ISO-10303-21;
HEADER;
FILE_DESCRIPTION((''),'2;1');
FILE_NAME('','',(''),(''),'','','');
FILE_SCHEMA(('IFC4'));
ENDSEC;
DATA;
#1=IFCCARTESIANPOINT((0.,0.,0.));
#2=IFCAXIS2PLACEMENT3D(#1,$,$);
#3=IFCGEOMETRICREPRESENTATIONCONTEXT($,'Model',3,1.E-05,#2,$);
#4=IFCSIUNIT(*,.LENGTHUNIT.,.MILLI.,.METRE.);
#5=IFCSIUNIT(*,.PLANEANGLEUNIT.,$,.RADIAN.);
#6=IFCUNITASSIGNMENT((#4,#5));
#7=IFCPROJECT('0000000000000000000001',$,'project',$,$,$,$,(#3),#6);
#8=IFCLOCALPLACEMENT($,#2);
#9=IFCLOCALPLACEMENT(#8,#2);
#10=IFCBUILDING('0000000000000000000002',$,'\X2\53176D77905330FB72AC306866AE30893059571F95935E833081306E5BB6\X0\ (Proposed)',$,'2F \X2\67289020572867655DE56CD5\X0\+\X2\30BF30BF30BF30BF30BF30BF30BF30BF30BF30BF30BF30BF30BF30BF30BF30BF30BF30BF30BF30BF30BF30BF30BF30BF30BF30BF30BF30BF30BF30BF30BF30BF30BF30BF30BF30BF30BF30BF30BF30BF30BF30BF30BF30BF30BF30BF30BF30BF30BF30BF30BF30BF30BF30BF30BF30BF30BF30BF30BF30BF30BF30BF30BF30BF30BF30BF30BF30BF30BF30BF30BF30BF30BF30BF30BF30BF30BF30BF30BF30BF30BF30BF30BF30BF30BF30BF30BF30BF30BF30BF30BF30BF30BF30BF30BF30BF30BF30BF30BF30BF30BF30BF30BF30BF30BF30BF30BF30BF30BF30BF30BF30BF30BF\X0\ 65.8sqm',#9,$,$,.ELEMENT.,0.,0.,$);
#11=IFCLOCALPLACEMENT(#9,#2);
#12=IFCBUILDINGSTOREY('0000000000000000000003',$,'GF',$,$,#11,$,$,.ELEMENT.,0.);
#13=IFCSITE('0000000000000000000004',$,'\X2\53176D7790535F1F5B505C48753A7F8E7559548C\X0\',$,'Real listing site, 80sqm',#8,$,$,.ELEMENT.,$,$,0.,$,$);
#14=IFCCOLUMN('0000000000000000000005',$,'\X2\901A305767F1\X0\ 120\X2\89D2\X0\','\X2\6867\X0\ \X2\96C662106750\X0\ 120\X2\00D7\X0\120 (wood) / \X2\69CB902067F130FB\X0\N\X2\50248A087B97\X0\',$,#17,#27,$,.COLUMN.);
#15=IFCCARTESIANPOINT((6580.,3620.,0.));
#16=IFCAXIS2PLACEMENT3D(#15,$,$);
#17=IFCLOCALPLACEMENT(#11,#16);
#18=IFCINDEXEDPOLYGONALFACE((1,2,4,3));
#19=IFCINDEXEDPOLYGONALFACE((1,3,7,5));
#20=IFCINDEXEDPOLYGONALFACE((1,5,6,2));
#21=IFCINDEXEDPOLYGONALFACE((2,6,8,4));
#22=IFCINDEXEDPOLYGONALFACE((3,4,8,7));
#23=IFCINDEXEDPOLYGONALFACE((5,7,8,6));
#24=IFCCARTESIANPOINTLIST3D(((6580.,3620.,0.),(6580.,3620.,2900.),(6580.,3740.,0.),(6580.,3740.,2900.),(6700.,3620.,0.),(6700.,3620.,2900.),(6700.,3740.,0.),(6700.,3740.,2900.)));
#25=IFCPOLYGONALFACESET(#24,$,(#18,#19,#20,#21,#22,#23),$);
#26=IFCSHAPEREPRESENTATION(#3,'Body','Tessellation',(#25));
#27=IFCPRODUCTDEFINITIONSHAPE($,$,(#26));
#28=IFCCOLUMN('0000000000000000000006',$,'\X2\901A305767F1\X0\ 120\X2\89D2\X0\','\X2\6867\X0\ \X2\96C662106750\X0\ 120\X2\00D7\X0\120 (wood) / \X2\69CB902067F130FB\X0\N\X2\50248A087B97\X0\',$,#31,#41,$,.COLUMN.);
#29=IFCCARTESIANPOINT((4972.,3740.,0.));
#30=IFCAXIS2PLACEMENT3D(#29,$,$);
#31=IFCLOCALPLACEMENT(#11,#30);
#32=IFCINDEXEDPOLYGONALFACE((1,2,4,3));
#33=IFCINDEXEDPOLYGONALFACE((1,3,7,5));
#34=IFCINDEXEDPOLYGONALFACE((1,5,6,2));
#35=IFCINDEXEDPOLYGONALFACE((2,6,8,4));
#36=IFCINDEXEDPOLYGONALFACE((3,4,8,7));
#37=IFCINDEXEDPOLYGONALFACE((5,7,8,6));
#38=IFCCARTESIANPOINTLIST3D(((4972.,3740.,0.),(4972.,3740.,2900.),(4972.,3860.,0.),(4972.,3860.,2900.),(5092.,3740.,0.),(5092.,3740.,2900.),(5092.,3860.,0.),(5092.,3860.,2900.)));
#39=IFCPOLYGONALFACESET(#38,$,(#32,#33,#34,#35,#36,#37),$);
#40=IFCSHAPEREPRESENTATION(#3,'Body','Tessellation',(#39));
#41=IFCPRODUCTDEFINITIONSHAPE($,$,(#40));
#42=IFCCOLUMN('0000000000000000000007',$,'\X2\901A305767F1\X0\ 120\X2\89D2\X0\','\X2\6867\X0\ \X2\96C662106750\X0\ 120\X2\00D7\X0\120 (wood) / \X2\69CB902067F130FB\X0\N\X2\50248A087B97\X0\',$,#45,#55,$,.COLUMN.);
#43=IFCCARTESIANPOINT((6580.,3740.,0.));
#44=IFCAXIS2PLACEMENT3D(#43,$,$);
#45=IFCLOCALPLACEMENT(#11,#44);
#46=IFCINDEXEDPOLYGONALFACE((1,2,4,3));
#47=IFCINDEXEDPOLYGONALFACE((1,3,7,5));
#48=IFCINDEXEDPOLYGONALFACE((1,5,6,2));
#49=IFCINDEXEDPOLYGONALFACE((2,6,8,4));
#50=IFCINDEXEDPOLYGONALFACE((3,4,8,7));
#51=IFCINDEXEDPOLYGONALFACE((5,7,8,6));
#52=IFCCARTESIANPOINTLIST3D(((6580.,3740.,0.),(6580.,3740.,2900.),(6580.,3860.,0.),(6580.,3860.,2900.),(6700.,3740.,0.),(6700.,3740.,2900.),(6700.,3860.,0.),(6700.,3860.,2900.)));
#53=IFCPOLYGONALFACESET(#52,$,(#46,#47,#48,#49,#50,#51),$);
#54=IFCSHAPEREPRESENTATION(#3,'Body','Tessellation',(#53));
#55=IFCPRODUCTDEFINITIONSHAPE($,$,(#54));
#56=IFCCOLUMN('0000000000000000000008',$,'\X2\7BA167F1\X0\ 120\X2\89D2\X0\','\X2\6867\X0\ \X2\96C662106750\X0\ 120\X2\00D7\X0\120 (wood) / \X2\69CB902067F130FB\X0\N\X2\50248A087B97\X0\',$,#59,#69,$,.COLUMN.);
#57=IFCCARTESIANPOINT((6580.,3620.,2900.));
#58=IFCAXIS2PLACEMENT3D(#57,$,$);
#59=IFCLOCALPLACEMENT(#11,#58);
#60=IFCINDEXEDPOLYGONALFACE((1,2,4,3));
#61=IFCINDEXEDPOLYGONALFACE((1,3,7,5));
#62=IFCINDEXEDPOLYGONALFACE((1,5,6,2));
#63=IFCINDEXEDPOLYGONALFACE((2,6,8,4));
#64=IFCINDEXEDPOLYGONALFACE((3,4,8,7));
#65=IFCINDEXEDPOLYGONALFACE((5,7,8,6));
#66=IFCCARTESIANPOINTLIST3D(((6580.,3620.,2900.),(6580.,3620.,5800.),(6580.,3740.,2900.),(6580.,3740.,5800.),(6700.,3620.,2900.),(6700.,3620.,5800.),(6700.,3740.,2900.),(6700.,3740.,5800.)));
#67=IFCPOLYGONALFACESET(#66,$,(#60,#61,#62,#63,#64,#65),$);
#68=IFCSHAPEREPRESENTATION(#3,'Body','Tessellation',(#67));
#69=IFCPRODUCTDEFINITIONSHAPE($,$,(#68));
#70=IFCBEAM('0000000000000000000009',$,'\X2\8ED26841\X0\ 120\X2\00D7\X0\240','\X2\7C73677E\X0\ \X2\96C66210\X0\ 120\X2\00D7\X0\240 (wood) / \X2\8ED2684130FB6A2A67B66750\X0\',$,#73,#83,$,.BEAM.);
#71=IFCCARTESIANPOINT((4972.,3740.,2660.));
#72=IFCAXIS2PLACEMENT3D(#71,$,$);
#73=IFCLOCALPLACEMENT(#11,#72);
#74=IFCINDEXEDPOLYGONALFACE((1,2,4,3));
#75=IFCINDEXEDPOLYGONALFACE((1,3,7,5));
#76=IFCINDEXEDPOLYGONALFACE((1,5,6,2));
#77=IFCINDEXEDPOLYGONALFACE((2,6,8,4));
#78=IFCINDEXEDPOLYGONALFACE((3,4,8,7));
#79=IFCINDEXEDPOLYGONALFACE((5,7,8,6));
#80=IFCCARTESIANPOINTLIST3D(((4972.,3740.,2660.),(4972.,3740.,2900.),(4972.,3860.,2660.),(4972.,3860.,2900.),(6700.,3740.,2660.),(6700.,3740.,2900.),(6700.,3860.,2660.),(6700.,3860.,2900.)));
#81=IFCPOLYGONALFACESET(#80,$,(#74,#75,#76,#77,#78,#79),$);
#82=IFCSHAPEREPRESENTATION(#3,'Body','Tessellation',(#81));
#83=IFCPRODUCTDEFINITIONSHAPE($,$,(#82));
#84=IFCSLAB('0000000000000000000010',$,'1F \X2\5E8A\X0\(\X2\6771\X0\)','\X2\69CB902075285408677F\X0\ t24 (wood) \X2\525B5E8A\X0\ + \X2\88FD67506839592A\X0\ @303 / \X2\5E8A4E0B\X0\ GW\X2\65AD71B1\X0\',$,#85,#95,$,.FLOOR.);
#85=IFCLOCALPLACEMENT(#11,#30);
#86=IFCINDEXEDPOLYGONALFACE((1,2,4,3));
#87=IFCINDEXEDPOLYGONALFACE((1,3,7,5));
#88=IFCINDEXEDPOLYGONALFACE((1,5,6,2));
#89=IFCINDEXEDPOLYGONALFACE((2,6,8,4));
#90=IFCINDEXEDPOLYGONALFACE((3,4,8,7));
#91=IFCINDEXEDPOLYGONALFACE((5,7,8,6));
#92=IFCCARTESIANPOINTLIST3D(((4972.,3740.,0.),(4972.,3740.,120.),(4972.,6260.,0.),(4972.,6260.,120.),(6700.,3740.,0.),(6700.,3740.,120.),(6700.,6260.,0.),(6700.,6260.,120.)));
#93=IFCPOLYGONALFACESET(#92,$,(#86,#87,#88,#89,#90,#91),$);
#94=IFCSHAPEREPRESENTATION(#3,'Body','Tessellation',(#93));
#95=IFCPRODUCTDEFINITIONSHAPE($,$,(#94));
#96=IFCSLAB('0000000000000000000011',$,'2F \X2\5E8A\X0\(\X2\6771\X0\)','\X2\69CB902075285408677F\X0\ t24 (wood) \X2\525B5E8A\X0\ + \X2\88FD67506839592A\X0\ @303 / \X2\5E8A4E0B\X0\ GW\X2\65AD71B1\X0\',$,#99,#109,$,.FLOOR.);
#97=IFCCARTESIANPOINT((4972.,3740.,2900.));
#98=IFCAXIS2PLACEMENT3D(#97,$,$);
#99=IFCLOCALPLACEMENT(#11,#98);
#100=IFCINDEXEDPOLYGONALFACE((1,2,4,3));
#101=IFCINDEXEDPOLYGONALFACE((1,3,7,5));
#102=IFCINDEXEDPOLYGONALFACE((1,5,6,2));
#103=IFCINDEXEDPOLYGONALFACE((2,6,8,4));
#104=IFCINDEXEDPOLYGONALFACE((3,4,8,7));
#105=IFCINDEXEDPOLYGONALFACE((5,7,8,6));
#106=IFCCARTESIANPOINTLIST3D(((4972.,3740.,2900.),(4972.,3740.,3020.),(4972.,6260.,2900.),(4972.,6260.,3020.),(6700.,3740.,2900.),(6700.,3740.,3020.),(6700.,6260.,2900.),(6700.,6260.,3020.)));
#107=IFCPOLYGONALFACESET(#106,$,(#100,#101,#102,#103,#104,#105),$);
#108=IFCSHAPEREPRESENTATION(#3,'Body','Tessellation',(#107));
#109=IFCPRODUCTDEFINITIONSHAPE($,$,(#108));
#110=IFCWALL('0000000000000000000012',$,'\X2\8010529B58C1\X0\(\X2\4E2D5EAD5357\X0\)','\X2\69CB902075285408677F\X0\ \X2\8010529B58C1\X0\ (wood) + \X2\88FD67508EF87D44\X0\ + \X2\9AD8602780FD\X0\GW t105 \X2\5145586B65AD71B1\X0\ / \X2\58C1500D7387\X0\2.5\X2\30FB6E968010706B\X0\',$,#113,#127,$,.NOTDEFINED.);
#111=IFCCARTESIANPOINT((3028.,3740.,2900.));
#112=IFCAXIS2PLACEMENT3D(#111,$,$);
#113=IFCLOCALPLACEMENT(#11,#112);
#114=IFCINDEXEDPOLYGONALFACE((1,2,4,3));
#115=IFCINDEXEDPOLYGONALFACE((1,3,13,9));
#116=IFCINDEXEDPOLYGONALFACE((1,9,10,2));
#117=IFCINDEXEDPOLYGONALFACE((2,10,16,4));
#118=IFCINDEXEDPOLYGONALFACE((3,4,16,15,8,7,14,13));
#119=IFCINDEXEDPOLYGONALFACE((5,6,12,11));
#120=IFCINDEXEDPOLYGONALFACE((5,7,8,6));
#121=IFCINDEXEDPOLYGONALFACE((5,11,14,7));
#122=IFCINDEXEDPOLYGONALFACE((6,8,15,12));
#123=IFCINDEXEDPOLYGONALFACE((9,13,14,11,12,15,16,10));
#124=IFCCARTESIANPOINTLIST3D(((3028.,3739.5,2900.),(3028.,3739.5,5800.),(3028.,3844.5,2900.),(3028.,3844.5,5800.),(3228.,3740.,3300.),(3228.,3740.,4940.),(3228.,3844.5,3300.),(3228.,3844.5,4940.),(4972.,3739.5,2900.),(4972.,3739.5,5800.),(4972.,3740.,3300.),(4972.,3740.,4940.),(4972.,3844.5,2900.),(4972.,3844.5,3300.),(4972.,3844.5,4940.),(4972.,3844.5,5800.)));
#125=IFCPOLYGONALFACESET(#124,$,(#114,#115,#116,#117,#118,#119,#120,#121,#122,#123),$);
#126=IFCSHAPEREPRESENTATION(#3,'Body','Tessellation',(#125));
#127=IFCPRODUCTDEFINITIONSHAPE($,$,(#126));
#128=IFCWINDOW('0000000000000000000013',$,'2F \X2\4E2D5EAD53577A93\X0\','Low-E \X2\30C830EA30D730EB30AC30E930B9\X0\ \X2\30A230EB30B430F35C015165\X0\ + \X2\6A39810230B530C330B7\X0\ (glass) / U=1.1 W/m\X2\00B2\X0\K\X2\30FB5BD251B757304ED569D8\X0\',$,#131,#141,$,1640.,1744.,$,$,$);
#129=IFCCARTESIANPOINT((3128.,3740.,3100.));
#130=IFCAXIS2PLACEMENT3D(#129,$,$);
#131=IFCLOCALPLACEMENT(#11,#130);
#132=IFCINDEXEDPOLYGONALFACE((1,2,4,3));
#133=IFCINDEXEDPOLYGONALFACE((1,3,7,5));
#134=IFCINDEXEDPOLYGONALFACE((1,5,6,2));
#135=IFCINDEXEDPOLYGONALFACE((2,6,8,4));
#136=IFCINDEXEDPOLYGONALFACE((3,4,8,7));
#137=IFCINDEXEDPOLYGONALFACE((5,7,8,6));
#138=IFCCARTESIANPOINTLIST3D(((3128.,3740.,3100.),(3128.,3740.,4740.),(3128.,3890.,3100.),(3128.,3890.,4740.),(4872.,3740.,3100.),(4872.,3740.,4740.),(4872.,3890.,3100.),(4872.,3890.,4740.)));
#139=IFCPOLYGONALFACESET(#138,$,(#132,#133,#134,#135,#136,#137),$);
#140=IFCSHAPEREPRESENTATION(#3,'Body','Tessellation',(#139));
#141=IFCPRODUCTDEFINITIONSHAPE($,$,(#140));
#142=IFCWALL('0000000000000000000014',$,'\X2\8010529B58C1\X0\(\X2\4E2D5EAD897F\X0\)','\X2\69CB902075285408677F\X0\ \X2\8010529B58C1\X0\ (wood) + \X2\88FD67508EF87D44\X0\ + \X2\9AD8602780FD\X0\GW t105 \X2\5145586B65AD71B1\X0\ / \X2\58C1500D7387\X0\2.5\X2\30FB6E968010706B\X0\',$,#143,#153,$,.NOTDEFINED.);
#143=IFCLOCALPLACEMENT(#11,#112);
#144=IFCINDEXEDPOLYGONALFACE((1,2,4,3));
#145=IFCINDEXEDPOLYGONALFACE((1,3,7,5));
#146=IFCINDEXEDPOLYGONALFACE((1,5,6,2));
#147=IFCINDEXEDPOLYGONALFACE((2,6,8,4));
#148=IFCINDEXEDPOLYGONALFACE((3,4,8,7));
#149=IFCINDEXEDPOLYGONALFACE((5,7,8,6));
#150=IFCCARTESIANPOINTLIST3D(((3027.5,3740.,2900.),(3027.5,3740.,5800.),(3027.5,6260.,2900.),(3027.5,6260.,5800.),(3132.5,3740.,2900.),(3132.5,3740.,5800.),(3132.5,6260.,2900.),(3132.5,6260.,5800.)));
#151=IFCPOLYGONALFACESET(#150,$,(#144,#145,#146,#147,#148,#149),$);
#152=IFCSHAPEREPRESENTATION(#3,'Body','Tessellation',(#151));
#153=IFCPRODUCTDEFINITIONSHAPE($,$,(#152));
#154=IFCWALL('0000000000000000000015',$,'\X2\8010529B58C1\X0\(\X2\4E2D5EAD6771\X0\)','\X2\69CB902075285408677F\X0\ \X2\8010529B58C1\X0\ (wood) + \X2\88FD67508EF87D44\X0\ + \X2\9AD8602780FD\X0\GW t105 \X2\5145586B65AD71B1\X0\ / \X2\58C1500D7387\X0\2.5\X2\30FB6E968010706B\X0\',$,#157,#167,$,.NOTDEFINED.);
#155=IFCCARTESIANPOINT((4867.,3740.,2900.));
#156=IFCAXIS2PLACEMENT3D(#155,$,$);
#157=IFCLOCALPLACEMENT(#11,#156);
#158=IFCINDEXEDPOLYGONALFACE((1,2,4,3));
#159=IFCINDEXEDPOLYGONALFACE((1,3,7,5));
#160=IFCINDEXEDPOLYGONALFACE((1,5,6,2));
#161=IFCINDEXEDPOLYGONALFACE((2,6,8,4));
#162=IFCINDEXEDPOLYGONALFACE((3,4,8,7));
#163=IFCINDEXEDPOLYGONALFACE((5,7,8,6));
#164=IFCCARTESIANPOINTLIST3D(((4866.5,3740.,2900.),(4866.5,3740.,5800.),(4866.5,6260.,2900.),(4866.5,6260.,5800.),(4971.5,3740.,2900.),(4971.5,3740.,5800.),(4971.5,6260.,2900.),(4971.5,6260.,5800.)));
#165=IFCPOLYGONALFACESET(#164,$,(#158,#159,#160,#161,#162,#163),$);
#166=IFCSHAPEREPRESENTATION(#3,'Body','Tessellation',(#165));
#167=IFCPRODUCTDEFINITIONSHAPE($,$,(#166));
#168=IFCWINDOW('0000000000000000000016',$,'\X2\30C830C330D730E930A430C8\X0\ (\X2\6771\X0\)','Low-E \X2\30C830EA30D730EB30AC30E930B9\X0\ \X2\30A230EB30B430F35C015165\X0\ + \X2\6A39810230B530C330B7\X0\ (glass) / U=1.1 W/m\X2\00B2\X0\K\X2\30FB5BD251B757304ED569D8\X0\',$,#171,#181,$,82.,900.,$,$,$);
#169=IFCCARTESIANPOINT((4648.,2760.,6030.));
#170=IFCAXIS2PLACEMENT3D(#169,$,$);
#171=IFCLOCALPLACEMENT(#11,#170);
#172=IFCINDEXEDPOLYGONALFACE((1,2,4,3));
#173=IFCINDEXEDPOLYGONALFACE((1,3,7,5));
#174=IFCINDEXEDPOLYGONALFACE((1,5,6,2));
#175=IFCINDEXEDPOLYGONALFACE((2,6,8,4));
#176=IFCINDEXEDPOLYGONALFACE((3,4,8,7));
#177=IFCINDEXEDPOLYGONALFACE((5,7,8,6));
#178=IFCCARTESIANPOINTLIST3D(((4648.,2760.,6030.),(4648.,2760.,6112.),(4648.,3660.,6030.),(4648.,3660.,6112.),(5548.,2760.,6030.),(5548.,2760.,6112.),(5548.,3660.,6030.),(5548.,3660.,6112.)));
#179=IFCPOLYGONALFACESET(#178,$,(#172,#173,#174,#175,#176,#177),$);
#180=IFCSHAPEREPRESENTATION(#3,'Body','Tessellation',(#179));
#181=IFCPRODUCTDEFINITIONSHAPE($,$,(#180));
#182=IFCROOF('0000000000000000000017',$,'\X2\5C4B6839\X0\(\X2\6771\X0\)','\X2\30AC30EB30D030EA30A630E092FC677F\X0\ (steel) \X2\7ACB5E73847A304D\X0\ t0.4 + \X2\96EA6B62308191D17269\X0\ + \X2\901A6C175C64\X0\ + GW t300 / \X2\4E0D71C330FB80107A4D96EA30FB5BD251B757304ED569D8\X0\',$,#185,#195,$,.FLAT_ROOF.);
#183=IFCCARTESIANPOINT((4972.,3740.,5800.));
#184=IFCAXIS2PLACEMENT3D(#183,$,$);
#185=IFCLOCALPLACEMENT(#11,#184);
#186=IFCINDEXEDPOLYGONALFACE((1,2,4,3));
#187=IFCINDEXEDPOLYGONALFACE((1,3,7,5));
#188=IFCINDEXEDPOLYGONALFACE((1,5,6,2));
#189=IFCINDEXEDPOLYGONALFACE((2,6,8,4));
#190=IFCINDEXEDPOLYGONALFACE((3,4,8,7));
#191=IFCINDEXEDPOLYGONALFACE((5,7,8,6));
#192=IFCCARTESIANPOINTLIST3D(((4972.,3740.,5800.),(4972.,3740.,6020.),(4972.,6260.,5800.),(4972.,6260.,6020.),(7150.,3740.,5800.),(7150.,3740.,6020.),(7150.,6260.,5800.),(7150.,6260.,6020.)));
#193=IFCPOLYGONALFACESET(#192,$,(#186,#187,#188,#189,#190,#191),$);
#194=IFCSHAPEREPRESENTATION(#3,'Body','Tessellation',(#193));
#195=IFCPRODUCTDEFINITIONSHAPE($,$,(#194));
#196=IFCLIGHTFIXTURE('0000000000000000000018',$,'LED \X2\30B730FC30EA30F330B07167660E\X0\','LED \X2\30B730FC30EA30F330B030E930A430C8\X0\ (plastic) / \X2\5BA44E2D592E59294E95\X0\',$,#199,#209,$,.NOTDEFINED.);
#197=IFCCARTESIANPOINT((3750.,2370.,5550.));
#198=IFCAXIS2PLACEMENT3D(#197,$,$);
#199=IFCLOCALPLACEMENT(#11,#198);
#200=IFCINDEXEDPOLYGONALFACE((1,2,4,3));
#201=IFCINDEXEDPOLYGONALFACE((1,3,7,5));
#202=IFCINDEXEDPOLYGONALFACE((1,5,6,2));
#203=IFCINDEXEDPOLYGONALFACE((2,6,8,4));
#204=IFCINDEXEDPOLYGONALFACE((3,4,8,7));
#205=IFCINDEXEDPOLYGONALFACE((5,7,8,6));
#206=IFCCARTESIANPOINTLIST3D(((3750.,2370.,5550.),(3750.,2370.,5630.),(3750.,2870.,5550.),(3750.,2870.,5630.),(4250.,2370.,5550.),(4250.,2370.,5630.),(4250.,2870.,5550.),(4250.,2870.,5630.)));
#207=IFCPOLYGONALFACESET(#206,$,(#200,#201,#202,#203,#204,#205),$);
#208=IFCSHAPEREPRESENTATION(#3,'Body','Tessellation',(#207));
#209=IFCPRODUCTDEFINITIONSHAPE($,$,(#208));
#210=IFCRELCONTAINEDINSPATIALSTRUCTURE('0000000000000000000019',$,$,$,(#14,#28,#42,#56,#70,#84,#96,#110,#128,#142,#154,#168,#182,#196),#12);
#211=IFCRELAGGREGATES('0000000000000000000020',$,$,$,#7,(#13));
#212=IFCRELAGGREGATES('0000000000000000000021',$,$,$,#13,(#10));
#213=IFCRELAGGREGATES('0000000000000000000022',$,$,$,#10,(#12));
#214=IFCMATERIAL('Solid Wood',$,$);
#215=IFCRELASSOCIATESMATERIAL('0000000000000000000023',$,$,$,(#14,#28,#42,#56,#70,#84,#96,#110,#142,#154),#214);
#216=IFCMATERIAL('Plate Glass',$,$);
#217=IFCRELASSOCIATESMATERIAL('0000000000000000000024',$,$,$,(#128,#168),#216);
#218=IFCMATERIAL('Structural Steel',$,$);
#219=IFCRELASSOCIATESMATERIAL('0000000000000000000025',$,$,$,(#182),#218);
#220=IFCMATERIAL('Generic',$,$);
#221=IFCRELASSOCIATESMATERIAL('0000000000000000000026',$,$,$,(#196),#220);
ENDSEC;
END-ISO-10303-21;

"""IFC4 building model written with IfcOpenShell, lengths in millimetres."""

from ifc_helpers import new_model, si_unit, frame, frame_2d, origin, place, context, project, spatial, rectangle, extrude, material, element, fill, save


model = new_model("IFC4")

# Units and contexts
model_context = context("Model", 3, precision=1e-05, world=origin())
ifc_project = project(units=[si_unit("LENGTHUNIT", "METRE", prefix="MILLI"), si_unit("PLANEANGLEUNIT", "RADIAN")], contexts=[model_context])

# Site, building, storey
site_placement = place(None, origin())
site = spatial("IfcSite", under=ifc_project, at=site_placement, Name="北海道弟子屈町美留和", ObjectType="Real listing site, 80sqm", CompositionType="ELEMENT", RefElevation=0.0)
building_placement = place(site_placement, origin())
building = spatial("IfcBuilding", under=site, at=building_placement, Name="北海道・犬と暮らす土間広めの家 (Proposed)", ObjectType="2F 木造在来工法+タタタタタタタタタタタタタタタタタタタタタタタタタタタタタタタタタタタタタタタタタタタタタタタタタタタタタタタタタタタタタタタタタタタタタタタタタタタタタタタタタタタタタタタタタタタタタタタタタタタタタタタタタタタタタタタタタ 65.8sqm", CompositionType="ELEMENT", ElevationOfRefHeight=0.0, ElevationOfTerrain=0.0)
storey_placement = place(building_placement, origin())
storey = spatial("IfcBuildingStorey", under=building, at=storey_placement, Name="GF", CompositionType="ELEMENT", Elevation=0.0)

# Columns
ifc_material_1 = material(Name="Solid Wood")
column_1_placement = place(storey_placement, frame((6580.0, 3620.0, 0.0)))
element("IfcColumn", 1, at=column_1_placement, inside=storey, material=ifc_material_1, Name="通し柱 120角", Description="桧 集成材 120×120 (wood) / 構造柱・N値計算", PredefinedType="COLUMN", context=model_context, shape_type="SweptSolid", body=[
    extrude(rectangle(XDim=120.0, YDim=120.0, at=frame_2d((60.0, 60.0))), frame((6580.0, 3620.0, 0.0)), (0.0, 0.0, 1.0), 2900.0),
])
column_2_placement = place(storey_placement, frame((4972.0, 3740.0, 0.0)))
element("IfcColumn", 2, at=column_2_placement, inside=storey, material=ifc_material_1, Name="通し柱 120角", Description="桧 集成材 120×120 (wood) / 構造柱・N値計算", PredefinedType="COLUMN", context=model_context, shape_type="SweptSolid", body=[
    extrude(rectangle(XDim=120.0, YDim=120.0, at=frame_2d((60.0, 60.0))), frame((4972.0, 3740.0, 0.0)), (0.0, 0.0, 1.0), 2900.0),
])
column_3_placement = place(storey_placement, frame((6580.0, 3740.0, 0.0)))
element("IfcColumn", 3, at=column_3_placement, inside=storey, material=ifc_material_1, Name="通し柱 120角", Description="桧 集成材 120×120 (wood) / 構造柱・N値計算", PredefinedType="COLUMN", context=model_context, shape_type="SweptSolid", body=[
    extrude(rectangle(XDim=120.0, YDim=120.0, at=frame_2d((60.0, 60.0))), frame((6580.0, 3740.0, 0.0)), (0.0, 0.0, 1.0), 2900.0),
])
column_4_placement = place(storey_placement, frame((6580.0, 3620.0, 2900.0)))
element("IfcColumn", 4, at=column_4_placement, inside=storey, material=ifc_material_1, Name="管柱 120角", Description="桧 集成材 120×120 (wood) / 構造柱・N値計算", PredefinedType="COLUMN", context=model_context, shape_type="SweptSolid", body=[
    extrude(rectangle(XDim=120.0, YDim=120.0, at=frame_2d((60.0, 60.0))), frame((6580.0, 3620.0, 2900.0)), (0.0, 0.0, 1.0), 2900.0),
])

# Beam
beam_1_placement = place(storey_placement, frame((4972.0, 3740.0, 2660.0)))
element("IfcBeam", 5, at=beam_1_placement, inside=storey, material=ifc_material_1, Name="軒桁 120×240", Description="米松 集成 120×240 (wood) / 軒桁・横架材", PredefinedType="BEAM", context=model_context, shape_type="SweptSolid", body=[
    extrude(rectangle(XDim=1728.0, YDim=120.0, at=frame_2d((864.0, 60.0))), frame((4972.0, 3740.0, 2660.0)), (0.0, 0.0, 1.0), 240.0),
])

# Slabs
slab_1_placement = place(storey_placement, frame((4972.0, 3740.0, 0.0)))
element("IfcSlab", 6, at=slab_1_placement, inside=storey, material=ifc_material_1, Name="1F 床(東)", Description="構造用合板 t24 (wood) 剛床 + 製材根太 @303 / 床下 GW断熱", PredefinedType="FLOOR", context=model_context, shape_type="SweptSolid", body=[
    extrude(rectangle(XDim=1728.0, YDim=2520.0, at=frame_2d((864.0, 1260.0))), frame((4972.0, 3740.0, 0.0)), (0.0, 0.0, 1.0), 120.0),
])
slab_2_placement = place(storey_placement, frame((4972.0, 3740.0, 2900.0)))
element("IfcSlab", 7, at=slab_2_placement, inside=storey, material=ifc_material_1, Name="2F 床(東)", Description="構造用合板 t24 (wood) 剛床 + 製材根太 @303 / 床下 GW断熱", PredefinedType="FLOOR", context=model_context, shape_type="SweptSolid", body=[
    extrude(rectangle(XDim=1728.0, YDim=2520.0, at=frame_2d((864.0, 1260.0))), frame((4972.0, 3740.0, 2900.0)), (0.0, 0.0, 1.0), 120.0),
])

# Wall, opening, window
wall_1_placement = place(storey_placement, frame((3028.0, 3740.0, 2900.0)))
wall_1 = element("IfcWall", 8, at=wall_1_placement, inside=storey, material=ifc_material_1, Name="耐力壁(中庭南)", Description="構造用合板 耐力壁 (wood) + 製材軸組 + 高性能GW t105 充填断熱 / 壁倍率2.5・準耐火", PredefinedType="NOTDEFINED", context=model_context, shape_type="SweptSolid", body=[
    extrude(rectangle(XDim=1944.0, YDim=105.0, at=frame_2d((972.0, 52.0))), frame((3028.0, 3740.0, 2900.0)), (0.0, 0.0, 1.0), 2900.0),
])
opening_placement = place(storey_placement, frame((3128.0, 3740.0, 3100.0)))
opening = element("IfcOpeningElement", 9, at=opening_placement, cuts=wall_1, PredefinedType="NOTDEFINED", context=model_context, shape_type="SweptSolid", body=[
    extrude(rectangle(XDim=1744.0, YDim=150.0, at=frame_2d((872.0, 75.0))), frame((3128.0, 3740.0, 3100.0)), (0.0, 0.0, 1.0), 1640.0),
])
ifc_material_2 = material(Name="Plate Glass")
window_1_placement = place(storey_placement, frame((3128.0, 3740.0, 3100.0)))
window_1 = element("IfcWindow", 10, at=window_1_placement, inside=storey, material=ifc_material_2, Name="2F 中庭南窓", Description="Low-E トリプルガラス アルゴン封入 + 樹脂サッシ (glass) / U=1.1 W/m²K・寒冷地仕様", OverallHeight=1640.0, OverallWidth=1744.0, context=model_context, shape_type="SweptSolid", body=[
    extrude(rectangle(XDim=1744.0, YDim=150.0, at=frame_2d((872.0, 75.0))), frame((3128.0, 3740.0, 3100.0)), (0.0, 0.0, 1.0), 1640.0),
])
fill(opening, window_1)

# Walls
wall_2_placement = place(storey_placement, frame((3028.0, 3740.0, 2900.0)))
element("IfcWall", 11, at=wall_2_placement, inside=storey, material=ifc_material_1, Name="耐力壁(中庭西)", Description="構造用合板 耐力壁 (wood) + 製材軸組 + 高性能GW t105 充填断熱 / 壁倍率2.5・準耐火", PredefinedType="NOTDEFINED", context=model_context, shape_type="SweptSolid", body=[
    extrude(rectangle(XDim=105.0, YDim=2520.0, at=frame_2d((52.0, 1260.0))), frame((3028.0, 3740.0, 2900.0)), (0.0, 0.0, 1.0), 2900.0),
])
wall_3_placement = place(storey_placement, frame((4867.0, 3740.0, 2900.0)))
element("IfcWall", 12, at=wall_3_placement, inside=storey, material=ifc_material_1, Name="耐力壁(中庭東)", Description="構造用合板 耐力壁 (wood) + 製材軸組 + 高性能GW t105 充填断熱 / 壁倍率2.5・準耐火", PredefinedType="NOTDEFINED", context=model_context, shape_type="SweptSolid", body=[
    extrude(rectangle(XDim=105.0, YDim=2520.0, at=frame_2d((52.0, 1260.0))), frame((4867.0, 3740.0, 2900.0)), (0.0, 0.0, 1.0), 2900.0),
])

# Window
window_2_placement = place(storey_placement, frame((4648.0, 2760.0, 6030.0)))
element("IfcWindow", 13, at=window_2_placement, inside=storey, material=ifc_material_2, Name="トップライト (東)", Description="Low-E トリプルガラス アルゴン封入 + 樹脂サッシ (glass) / U=1.1 W/m²K・寒冷地仕様", OverallHeight=82.0, OverallWidth=900.0, context=model_context, shape_type="SweptSolid", body=[
    extrude(rectangle(XDim=900.0, YDim=900.0, at=frame_2d((450.0, 450.0))), frame((4648.0, 2760.0, 6030.0)), (0.0, 0.0, 1.0), 82.0),
])

# Roof
ifc_material_3 = material(Name="Structural Steel")
for number, where, name in (
    (14, (4972.0, 3740.0, 5800.0), "屋根(東)"),
):
    element("IfcRoof", number, at=place(storey_placement, frame(where)), inside=storey, material=ifc_material_3, Name=name, Description="ガルバリウム鋼板 (steel) 立平葺き t0.4 + 雪止め金物 + 通気層 + GW t300 / 不燃・耐積雪・寒冷地仕様", PredefinedType="FLAT_ROOF", context=model_context, shape_type="SweptSolid", body=[
        extrude(rectangle(XDim=2178.0, YDim=2520.0, at=frame_2d((1089.0, 1260.0))), frame((4972.0, 3740.0, 5800.0)), (0.0, 0.0, 1.0), 220.0),
    ])

# Light fixture
ifc_material_4 = material(Name="Generic")
light_fixture_placement = place(storey_placement, frame((3750.0, 2370.0, 5550.0)))
element("IfcLightFixture", 15, at=light_fixture_placement, inside=storey, material=ifc_material_4, Name="LED シーリング照明", Description="LED シーリングライト (plastic) / 室中央天井", PredefinedType="NOTDEFINED", context=model_context, shape_type="SweptSolid", body=[
    extrude(rectangle(XDim=500.0, YDim=500.0, at=frame_2d((250.0, 250.0))), frame((3750.0, 2370.0, 5550.0)), (0.0, 0.0, 1.0), 80.0),
])

save(model, "model.ifc")
